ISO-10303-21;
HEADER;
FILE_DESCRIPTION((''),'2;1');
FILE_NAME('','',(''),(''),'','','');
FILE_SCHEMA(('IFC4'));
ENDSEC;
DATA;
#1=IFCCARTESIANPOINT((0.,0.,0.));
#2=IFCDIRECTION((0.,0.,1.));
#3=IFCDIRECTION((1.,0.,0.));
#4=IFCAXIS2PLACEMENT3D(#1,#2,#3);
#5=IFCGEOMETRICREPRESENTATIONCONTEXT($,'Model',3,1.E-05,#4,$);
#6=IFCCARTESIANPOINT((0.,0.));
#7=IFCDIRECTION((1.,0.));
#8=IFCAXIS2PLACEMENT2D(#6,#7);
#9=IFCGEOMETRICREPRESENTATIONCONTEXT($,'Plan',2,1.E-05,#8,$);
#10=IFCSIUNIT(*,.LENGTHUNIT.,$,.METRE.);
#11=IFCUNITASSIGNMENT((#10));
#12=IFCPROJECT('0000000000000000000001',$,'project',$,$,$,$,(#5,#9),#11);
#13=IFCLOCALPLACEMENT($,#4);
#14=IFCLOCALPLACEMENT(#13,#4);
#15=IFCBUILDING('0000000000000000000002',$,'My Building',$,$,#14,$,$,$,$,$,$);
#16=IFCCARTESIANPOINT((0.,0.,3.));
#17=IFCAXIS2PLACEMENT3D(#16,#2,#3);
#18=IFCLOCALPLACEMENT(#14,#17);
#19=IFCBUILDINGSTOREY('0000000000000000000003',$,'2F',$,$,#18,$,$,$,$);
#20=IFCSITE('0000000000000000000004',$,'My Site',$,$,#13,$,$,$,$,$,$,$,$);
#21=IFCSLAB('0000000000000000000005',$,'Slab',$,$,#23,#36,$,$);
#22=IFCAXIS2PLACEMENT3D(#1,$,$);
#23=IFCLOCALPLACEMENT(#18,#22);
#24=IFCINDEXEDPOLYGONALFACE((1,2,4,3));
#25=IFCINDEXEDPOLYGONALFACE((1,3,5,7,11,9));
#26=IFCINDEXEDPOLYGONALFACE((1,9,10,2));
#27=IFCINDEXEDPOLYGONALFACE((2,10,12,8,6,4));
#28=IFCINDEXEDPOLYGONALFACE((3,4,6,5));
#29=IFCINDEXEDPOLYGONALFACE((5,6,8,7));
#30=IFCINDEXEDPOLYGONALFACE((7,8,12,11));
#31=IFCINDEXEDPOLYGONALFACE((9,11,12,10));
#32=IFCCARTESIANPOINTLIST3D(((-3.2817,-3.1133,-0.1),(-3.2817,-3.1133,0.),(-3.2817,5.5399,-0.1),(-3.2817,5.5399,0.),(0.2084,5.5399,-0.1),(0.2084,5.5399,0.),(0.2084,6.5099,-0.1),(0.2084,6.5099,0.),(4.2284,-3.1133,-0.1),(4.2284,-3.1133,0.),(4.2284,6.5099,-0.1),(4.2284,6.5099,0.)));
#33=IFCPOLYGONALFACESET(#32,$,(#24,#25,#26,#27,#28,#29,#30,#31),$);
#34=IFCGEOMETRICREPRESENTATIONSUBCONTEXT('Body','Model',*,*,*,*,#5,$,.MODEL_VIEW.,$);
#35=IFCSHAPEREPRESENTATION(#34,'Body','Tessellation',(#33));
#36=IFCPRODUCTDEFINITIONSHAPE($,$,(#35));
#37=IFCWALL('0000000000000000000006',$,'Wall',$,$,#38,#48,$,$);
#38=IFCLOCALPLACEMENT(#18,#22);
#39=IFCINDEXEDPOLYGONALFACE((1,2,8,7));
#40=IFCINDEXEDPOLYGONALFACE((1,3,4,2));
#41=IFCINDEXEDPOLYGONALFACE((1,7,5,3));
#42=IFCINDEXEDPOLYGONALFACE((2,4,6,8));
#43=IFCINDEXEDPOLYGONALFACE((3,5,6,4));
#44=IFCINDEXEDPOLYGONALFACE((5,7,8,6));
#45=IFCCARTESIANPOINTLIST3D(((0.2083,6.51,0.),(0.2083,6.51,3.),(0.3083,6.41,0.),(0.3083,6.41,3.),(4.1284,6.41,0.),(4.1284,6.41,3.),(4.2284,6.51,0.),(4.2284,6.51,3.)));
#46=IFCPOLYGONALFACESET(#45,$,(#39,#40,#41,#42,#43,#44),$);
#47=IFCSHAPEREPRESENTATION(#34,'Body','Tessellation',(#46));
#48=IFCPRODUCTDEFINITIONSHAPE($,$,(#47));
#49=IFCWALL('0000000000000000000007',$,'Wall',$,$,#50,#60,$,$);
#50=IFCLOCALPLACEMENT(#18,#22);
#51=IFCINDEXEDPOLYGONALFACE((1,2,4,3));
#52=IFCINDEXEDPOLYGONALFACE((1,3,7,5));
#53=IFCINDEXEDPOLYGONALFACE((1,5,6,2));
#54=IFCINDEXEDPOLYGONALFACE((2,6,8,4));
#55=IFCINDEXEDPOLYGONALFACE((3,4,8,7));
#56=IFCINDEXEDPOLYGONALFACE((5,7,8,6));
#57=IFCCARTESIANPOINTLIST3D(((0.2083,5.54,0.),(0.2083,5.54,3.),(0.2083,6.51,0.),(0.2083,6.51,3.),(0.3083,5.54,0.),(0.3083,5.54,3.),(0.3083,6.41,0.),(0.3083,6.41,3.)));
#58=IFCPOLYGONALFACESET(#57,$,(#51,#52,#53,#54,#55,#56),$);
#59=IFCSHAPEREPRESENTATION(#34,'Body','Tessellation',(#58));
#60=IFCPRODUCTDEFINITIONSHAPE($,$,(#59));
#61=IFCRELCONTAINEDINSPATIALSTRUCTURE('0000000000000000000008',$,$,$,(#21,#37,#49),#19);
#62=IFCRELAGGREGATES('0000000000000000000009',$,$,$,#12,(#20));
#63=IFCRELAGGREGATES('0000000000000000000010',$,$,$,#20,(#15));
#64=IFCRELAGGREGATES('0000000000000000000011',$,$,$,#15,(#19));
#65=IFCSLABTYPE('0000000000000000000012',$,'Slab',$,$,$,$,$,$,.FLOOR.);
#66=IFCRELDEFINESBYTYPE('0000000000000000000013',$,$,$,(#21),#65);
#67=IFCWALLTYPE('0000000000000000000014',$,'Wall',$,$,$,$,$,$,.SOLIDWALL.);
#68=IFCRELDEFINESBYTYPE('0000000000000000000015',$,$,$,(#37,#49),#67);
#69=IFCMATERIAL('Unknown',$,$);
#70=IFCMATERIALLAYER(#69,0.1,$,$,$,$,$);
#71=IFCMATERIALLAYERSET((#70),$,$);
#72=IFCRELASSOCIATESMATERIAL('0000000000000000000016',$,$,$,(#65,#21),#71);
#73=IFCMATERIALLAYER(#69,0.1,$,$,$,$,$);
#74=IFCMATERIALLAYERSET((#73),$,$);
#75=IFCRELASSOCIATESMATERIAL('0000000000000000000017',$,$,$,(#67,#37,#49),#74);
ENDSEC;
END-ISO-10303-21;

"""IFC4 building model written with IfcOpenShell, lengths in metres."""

from ifc_helpers import new_model, si_unit, frame, origin_with_axes, origin_2d_with_axis, place, context, subcontext, project, spatial, line, indexed_curve, outline, extrude, material, layer, layer_set, layer_usage, type_object, element, save


model = new_model("IFC4")

# Units and contexts
model_context = context("Model", 3, precision=1e-05, world=origin_with_axes())
plan_context = context("Plan", 2, precision=1e-05, world=origin_2d_with_axis())
body_context_1 = subcontext(model_context, "Body", "Model", "MODEL_VIEW")
ifc_project = project(units=[si_unit("LENGTHUNIT", "METRE")], contexts=[model_context, plan_context])

# Site, building, storey
site_placement = place(None, origin_with_axes())
site = spatial("IfcSite", under=ifc_project, at=site_placement, Name="My Site")
building_placement = place(site_placement, origin_with_axes())
building = spatial("IfcBuilding", under=site, at=building_placement, Name="My Building")
storey_placement = place(building_placement, frame((0.0, 0.0, 3.0), z_axis=(0.0, 0.0, 1.0), x_axis=(1.0, 0.0, 0.0)))
storey = spatial("IfcBuildingStorey", under=building, at=storey_placement, Name="2F")

# Slab
ifc_material = material(Name="Unknown")
ifc_layer_1 = layer(ifc_material, 0.1)
ifc_layer_set_1 = layer_set([ifc_layer_1])
ifc_layer_usage_1 = layer_usage(ifc_layer_set_1, "AXIS3", "POSITIVE", -0.1)
slab_type = type_object("IfcSlabType", Name="Slab", PredefinedType="FLOOR", material=ifc_layer_set_1)
slab_placement = place(storey_placement, frame((4.2284, 6.5099, 0.0), z_axis=(0.0, 0.0, 1.0), x_axis=(1.0, 0.0, 0.0)))
element("IfcSlab", 1, at=slab_placement, inside=storey, type_object=slab_type, material=ifc_layer_usage_1, Name="Slab", context=body_context_1, shape_type="SweptSolid", body=[
    extrude(outline(indexed_curve([(0.0, 0.0), (-4.02, 0.0), (-4.02, -0.97), (-7.5101, -0.97), (-7.5101, -9.6233), (0.0, -9.6233), (0.0, 0.0)])), frame((0.0, 0.0, -0.1), z_axis=(0.0, 0.0, 1.0), x_axis=(1.0, 0.0, 0.0)), (0.0, 0.0, 1.0), 0.1),
])

# Walls
ifc_layer_2 = layer(ifc_material, 0.1)
ifc_layer_set_2 = layer_set([ifc_layer_2])
ifc_layer_usage_2 = layer_usage(ifc_layer_set_2, "AXIS2", "POSITIVE", 0.0)
wall_type = type_object("IfcWallType", Name="Wall", PredefinedType="SOLIDWALL", material=ifc_layer_set_2)
wall_1_placement = place(storey_placement, frame((4.2284, 6.51, 0.0), z_axis=(0.0, 0.0, 1.0), x_axis=(-1.0, 0.0, 0.0)))
element("IfcWall", 2, at=wall_1_placement, inside=storey, type_object=wall_type, material=ifc_layer_usage_2, Name="Wall", context=body_context_1, shape_type="SweptSolid", body=[
    extrude(outline(indexed_curve([(0.0, 0.0), (0.1, 0.1), (3.92, 0.1), (4.02, 0.0)], segments=[line(1, 2, 3, 4, 1)])), origin_with_axes(), (0.0, 0.0, 1.0), 3.0),
])
ifc_layer_usage_3 = layer_usage(ifc_layer_set_2, "AXIS2", "POSITIVE", 0.0)
wall_2_placement = place(storey_placement, frame((0.2083, 6.51, 0.0), z_axis=(0.0, 0.0, 1.0), x_axis=(0.0, -1.0, 0.0)))
element("IfcWall", 3, at=wall_2_placement, inside=storey, type_object=wall_type, material=ifc_layer_usage_3, Name="Wall", context=body_context_1, shape_type="SweptSolid", body=[
    extrude(outline(indexed_curve([(0.0, 0.0), (0.1, 0.1), (0.97, 0.1), (0.97, 0.0)], segments=[line(1, 2, 3, 4, 1)])), origin_with_axes(), (0.0, 0.0, 1.0), 3.0),
])

save(model, "model.ifc")
